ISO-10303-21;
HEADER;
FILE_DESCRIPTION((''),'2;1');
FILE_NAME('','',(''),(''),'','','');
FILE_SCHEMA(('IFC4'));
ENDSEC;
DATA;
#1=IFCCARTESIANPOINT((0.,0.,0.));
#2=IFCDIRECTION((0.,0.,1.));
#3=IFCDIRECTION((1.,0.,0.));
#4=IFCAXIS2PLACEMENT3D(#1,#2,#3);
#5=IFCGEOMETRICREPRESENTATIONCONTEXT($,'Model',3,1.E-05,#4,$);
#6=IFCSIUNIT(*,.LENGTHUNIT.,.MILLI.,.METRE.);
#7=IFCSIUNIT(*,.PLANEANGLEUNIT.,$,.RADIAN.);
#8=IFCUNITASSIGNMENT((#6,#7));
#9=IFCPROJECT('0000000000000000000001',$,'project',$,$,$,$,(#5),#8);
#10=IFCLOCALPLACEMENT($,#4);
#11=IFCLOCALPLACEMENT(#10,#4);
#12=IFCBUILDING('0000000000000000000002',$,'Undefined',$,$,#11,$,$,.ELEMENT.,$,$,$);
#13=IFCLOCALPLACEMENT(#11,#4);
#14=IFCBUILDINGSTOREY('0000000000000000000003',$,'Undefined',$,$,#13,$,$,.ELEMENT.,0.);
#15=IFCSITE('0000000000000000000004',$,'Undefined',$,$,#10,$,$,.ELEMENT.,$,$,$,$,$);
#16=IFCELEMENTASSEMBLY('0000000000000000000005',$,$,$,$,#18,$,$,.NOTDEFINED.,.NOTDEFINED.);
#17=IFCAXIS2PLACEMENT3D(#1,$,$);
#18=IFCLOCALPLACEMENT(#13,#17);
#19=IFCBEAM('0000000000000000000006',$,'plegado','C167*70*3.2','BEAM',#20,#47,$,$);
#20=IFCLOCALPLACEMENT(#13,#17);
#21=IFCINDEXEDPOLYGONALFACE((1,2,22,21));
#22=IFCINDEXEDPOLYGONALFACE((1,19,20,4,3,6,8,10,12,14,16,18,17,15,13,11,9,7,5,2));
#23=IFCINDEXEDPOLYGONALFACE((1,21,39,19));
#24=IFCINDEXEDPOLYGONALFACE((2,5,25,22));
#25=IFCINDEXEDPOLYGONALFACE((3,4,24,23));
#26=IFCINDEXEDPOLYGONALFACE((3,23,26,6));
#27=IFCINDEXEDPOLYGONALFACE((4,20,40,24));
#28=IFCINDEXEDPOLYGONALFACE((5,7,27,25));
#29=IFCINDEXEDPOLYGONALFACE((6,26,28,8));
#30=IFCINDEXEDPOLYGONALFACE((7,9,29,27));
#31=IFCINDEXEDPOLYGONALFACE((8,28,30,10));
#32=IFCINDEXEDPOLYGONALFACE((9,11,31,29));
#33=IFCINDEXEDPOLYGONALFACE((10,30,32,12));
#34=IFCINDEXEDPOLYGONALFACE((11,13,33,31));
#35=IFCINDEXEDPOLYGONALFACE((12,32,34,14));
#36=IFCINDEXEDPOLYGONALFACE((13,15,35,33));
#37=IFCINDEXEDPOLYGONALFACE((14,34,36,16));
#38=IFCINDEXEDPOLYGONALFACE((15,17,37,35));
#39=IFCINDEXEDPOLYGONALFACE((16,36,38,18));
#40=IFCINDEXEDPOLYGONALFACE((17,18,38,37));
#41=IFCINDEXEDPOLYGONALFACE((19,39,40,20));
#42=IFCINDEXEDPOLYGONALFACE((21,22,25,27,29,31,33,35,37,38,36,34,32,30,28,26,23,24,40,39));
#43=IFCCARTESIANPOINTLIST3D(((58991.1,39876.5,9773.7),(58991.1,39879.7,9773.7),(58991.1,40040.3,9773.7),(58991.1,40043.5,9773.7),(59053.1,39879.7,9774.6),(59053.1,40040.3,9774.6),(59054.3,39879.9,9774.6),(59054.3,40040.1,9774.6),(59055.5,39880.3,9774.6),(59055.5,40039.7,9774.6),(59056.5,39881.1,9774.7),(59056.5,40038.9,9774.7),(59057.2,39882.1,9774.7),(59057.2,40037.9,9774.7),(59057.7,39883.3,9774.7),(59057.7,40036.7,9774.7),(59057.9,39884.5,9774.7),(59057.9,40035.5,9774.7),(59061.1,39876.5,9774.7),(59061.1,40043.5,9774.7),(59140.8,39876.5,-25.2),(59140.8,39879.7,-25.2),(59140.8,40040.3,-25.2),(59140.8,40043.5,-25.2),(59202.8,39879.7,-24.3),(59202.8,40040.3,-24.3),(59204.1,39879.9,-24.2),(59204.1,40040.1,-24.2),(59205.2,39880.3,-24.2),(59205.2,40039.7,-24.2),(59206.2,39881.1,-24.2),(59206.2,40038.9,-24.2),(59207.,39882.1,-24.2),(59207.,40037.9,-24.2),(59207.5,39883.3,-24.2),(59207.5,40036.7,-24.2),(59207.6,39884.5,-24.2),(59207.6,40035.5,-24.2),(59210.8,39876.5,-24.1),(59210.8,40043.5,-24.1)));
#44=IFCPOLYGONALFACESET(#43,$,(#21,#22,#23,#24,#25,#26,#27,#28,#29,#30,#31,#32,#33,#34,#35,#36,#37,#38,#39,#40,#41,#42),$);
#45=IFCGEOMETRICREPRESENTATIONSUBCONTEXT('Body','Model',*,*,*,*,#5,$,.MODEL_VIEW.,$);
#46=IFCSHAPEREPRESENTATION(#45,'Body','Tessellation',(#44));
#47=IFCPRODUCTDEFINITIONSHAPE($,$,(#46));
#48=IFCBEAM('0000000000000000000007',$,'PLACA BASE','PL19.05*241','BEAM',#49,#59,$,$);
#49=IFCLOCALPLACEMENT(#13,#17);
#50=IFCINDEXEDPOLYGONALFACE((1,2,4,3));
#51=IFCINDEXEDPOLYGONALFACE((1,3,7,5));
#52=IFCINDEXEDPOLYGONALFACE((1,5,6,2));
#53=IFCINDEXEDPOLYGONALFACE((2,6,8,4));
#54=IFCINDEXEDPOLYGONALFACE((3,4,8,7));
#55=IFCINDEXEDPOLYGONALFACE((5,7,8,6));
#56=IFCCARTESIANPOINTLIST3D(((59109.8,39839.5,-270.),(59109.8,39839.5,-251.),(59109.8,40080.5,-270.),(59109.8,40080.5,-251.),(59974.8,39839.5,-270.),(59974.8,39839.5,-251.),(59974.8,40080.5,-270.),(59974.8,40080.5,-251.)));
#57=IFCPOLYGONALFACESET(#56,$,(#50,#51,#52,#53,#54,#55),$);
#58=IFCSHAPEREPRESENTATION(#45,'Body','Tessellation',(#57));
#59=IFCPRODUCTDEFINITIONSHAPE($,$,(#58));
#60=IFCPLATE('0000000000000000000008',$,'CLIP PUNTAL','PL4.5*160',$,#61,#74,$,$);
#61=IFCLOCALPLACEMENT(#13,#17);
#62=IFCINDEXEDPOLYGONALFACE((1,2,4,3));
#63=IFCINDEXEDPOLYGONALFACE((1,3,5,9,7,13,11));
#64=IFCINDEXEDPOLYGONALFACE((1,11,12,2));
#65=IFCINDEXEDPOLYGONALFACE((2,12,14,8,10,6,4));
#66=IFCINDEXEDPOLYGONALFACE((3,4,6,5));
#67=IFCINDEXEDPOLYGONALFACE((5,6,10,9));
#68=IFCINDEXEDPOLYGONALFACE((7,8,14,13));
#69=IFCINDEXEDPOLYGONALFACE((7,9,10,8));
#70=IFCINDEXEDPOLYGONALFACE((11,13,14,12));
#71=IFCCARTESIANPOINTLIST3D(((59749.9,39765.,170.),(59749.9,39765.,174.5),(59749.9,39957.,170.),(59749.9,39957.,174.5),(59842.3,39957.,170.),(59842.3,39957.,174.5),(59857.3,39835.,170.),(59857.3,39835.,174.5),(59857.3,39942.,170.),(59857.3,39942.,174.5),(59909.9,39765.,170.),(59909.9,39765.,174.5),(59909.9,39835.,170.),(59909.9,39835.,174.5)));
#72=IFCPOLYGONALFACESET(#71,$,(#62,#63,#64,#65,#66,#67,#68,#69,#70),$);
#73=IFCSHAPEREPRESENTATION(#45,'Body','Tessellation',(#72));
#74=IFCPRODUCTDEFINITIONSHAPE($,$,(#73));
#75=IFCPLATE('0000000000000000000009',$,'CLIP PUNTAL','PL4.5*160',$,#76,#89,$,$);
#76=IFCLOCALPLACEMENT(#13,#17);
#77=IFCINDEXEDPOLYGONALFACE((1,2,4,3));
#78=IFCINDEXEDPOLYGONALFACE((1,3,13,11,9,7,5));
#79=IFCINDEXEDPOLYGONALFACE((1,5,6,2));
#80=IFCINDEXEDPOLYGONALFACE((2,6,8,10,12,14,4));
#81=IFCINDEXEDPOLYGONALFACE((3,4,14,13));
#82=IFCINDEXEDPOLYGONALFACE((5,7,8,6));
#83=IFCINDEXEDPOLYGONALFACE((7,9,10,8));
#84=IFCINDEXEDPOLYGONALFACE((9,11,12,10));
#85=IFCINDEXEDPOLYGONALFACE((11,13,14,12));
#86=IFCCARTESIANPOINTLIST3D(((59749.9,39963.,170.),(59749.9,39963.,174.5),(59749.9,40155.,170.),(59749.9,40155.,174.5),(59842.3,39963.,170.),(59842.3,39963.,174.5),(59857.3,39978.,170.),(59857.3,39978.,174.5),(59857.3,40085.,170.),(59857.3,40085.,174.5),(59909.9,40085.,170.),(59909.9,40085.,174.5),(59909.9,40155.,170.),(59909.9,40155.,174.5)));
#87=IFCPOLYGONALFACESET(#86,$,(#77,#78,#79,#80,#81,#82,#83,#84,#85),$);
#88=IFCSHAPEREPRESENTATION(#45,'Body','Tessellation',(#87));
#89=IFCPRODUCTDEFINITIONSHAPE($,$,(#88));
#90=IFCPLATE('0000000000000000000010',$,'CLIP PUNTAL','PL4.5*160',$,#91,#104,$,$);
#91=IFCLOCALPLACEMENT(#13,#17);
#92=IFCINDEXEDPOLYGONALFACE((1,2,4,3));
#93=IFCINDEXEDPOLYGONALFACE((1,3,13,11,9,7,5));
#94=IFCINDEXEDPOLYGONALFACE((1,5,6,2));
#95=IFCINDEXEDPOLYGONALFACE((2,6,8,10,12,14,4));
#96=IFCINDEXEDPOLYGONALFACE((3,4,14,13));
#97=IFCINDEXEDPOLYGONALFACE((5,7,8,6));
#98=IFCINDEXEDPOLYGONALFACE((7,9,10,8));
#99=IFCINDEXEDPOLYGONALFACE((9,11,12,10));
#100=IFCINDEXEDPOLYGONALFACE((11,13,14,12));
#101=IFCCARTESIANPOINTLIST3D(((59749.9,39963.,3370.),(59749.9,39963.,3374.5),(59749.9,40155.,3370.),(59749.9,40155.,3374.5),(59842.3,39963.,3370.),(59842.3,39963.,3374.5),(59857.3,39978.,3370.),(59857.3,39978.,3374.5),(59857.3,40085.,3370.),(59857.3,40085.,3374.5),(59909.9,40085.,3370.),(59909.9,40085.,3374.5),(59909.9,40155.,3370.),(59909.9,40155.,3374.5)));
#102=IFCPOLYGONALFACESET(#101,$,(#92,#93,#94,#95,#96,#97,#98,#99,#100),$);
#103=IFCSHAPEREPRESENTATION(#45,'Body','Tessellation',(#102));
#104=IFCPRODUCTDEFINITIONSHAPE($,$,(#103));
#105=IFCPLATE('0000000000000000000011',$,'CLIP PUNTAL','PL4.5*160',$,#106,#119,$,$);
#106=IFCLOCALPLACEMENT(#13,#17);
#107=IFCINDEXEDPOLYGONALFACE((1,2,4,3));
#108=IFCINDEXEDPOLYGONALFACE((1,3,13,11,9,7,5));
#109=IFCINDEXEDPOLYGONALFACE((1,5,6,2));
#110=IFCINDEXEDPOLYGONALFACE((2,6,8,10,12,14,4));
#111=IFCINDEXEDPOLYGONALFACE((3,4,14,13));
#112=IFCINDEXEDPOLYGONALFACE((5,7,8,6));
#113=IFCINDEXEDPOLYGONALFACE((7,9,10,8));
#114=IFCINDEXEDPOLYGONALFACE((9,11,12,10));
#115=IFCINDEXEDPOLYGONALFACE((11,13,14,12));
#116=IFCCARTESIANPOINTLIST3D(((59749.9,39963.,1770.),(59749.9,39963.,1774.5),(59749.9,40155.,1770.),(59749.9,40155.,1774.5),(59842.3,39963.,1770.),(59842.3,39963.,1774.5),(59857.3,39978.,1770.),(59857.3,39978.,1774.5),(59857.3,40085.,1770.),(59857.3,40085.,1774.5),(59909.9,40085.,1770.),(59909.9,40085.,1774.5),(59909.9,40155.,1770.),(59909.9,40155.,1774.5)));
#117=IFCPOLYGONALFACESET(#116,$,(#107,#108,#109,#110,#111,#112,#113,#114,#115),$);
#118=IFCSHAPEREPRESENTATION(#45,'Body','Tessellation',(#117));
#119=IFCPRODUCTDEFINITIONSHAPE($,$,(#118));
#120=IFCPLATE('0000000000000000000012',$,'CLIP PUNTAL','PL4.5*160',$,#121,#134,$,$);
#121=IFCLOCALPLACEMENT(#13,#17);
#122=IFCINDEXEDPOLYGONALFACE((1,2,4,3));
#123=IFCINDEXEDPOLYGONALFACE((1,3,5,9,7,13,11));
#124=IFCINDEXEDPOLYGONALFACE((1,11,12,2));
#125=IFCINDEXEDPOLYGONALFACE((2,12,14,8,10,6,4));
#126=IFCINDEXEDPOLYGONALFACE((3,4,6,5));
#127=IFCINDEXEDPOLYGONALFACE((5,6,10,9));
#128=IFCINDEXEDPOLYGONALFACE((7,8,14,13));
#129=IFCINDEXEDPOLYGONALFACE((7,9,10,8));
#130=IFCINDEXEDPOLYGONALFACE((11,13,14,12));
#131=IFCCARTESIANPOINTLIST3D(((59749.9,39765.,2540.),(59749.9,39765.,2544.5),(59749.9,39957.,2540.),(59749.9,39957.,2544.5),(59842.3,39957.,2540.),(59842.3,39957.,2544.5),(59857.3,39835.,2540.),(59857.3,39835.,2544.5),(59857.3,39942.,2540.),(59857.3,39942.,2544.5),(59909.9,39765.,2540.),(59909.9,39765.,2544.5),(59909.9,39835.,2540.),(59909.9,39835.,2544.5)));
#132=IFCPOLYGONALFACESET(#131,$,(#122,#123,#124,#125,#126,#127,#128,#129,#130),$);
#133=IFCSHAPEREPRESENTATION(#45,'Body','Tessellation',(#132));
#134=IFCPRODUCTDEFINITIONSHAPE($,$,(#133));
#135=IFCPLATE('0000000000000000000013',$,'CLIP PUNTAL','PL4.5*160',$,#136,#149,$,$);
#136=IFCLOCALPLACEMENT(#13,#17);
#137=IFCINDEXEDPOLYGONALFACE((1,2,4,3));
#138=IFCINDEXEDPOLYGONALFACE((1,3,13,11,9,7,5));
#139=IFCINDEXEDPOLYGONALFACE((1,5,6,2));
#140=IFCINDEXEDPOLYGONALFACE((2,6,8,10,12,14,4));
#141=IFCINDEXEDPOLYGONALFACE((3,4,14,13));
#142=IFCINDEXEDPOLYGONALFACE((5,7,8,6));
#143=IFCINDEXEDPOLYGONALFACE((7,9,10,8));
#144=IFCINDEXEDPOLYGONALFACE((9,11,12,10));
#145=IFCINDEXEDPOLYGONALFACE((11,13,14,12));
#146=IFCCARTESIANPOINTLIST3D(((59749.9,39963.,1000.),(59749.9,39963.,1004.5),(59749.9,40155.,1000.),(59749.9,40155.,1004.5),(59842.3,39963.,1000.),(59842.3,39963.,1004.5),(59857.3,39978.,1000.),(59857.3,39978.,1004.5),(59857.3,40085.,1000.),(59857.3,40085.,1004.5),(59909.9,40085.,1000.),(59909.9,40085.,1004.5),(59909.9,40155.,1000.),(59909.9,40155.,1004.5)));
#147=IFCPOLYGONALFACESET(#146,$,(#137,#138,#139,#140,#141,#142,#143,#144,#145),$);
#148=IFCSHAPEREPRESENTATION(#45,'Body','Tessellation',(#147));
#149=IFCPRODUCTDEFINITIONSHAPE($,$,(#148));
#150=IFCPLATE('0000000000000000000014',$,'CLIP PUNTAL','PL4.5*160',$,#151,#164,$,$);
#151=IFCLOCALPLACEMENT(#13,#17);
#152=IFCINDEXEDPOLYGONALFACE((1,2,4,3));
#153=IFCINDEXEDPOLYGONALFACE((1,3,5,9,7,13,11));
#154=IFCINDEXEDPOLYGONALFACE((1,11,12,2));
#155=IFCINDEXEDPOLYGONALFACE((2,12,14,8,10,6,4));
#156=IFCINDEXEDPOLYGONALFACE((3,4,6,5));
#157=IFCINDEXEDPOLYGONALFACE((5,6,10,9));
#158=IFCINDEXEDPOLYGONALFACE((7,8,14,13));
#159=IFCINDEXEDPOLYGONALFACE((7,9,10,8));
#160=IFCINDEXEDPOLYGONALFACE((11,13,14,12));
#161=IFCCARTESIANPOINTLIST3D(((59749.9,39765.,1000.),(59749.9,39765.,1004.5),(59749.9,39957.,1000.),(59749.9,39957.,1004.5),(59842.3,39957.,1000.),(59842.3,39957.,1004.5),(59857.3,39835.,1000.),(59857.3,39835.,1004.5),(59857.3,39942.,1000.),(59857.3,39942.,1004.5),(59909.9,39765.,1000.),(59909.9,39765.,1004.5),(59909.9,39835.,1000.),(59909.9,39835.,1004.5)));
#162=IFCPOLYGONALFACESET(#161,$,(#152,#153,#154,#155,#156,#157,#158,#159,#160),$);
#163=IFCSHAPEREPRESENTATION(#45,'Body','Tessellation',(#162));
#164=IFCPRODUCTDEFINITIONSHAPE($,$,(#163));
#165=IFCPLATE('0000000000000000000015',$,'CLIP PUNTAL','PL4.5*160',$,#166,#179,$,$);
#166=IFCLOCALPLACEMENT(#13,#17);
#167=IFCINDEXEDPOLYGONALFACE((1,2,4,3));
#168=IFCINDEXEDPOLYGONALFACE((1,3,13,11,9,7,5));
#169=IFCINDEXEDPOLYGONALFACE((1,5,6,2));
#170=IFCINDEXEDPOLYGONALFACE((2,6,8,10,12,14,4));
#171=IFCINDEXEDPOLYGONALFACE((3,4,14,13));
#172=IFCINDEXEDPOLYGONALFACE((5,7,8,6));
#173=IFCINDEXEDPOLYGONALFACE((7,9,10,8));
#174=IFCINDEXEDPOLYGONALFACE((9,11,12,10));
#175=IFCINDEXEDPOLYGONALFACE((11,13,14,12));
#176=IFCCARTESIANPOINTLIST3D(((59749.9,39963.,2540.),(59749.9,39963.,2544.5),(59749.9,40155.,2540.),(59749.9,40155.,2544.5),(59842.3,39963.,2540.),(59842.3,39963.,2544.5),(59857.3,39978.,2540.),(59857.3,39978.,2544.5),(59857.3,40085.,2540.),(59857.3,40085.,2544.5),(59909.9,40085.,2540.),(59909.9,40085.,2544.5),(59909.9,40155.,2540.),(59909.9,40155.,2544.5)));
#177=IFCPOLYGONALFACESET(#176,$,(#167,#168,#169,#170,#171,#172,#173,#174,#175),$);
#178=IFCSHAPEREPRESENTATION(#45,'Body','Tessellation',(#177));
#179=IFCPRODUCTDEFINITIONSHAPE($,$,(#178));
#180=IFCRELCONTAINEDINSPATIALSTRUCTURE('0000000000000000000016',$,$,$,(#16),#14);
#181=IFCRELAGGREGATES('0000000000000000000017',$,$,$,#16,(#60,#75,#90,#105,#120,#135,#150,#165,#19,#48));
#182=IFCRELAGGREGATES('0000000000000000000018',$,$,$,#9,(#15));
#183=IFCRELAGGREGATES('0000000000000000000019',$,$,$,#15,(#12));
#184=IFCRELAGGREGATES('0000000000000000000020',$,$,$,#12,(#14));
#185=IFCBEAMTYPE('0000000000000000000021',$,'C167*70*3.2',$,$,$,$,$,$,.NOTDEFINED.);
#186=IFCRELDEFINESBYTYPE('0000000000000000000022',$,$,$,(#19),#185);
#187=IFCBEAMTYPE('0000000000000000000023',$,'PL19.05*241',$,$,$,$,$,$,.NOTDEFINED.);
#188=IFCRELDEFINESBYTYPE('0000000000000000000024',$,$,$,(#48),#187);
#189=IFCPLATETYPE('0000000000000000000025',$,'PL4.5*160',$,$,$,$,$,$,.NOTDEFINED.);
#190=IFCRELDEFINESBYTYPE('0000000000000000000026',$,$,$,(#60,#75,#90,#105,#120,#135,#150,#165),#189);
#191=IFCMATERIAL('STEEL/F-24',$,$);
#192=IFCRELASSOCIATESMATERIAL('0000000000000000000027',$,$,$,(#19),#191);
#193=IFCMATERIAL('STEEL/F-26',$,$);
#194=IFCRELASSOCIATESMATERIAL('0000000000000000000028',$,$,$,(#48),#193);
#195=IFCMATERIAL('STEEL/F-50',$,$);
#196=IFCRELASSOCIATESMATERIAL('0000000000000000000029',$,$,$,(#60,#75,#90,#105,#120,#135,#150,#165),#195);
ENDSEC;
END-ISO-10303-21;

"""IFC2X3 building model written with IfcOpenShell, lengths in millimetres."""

from ifc_helpers import new_model, si_unit, frame, origin_with_axes, origin_2d_with_axis, place, context, subcontext, project, spatial, polyline, rectangle, u_section, outline, extrude, material, type_object, element, aggregate, save


model = new_model("IFC2X3")

# Units and contexts
model_context = context("Model", 3, precision=1e-05, world=origin_with_axes())
body_context = subcontext(model_context, "Body", "Model", "MODEL_VIEW")
ifc_project = project(units=[si_unit("LENGTHUNIT", "METRE", prefix="MILLI"), si_unit("PLANEANGLEUNIT", "RADIAN")], contexts=[model_context])

# Site, building, storey
site_placement = place(None, origin_with_axes())
site = spatial("IfcSite", under=ifc_project, at=site_placement, Name="Undefined", CompositionType="ELEMENT")
building_placement = place(site_placement, origin_with_axes())
building = spatial("IfcBuilding", under=site, at=building_placement, Name="Undefined", CompositionType="ELEMENT")
storey_placement = place(building_placement, origin_with_axes())
storey = spatial("IfcBuildingStorey", under=building, at=storey_placement, Name="Undefined", CompositionType="ELEMENT", Elevation=0.0)

# Element assembly, beams, plates
assembly_1_placement = place(storey_placement, origin_with_axes())
assembly_1 = element("IfcElementAssembly", 1, at=assembly_1_placement, inside=storey, AssemblyPlace="NOTDEFINED", PredefinedType="NOTDEFINED")
ifc_material_1 = material(Name="STEEL/F-24")
beam_type_1 = type_object("IfcBeamType", Name="C167*70*3.2", PredefinedType="NOTDEFINED")
beam_1_placement = place(assembly_1_placement, frame((59175.8, 39960.0, -24.7), z_axis=(0.0, 1.0, 0.0), x_axis=(-0.015279, 0.0, 0.999883)))
beam_1 = element("IfcBeam", 2, at=beam_1_placement, type_object=beam_type_1, material=ifc_material_1, Name="plegado", Description="C167*70*3.2", ObjectType="BEAM", context=body_context, shape_type="SweptSolid", body=[
    extrude(u_section(Depth=167.0, FlangeWidth=70.0, WebThickness=3.2, FlangeThickness=3.2, FilletRadius=4.8, at=origin_2d_with_axis()), frame((9800.0, 0.0, 0.0), z_axis=(-1.0, 0.0, 0.0), x_axis=(0.0, -1.0, 0.0)), (0.0, 0.0, 1.0), 9800.0),
])
ifc_material_2 = material(Name="STEEL/F-26")
beam_type_2 = type_object("IfcBeamType", Name="PL19.05*241", PredefinedType="NOTDEFINED")
beam_2_placement = place(assembly_1_placement, frame((59974.8, 39960.0, -260.5), z_axis=(0.0, -1.0, 0.0), x_axis=(-1.0, 0.0, 0.0)))
beam_2 = element("IfcBeam", 3, at=beam_2_placement, type_object=beam_type_2, material=ifc_material_2, Name="PLACA BASE", Description="PL19.05*241", ObjectType="BEAM", context=body_context, shape_type="SweptSolid", body=[
    extrude(rectangle(XDim=19.1, YDim=241.0, at=origin_2d_with_axis()), frame((865.0, 0.0, 0.0), z_axis=(-1.0, 0.0, 0.0), x_axis=(0.0, -1.0, 0.0)), (0.0, 0.0, 1.0), 865.0),
])
ifc_material_3 = material(Name="STEEL/F-50")
plate_type_1 = type_object("IfcPlateType", Name="PL4.5*160", PredefinedType="NOTDEFINED")
plate_1_placement = place(assembly_1_placement, frame((59857.3, 39957.0, 172.3), z_axis=(0.0, 0.0, -1.0), x_axis=(0.0, -1.0, 0.0)))
plate_1 = element("IfcPlate", 4, at=plate_1_placement, type_object=plate_type_1, material=ifc_material_3, Name="CLIP PUNTAL", Description="PL4.5*160", context=body_context, shape_type="SweptSolid", body=[
    extrude(outline(polyline([(0.0, 15.0), (15.0, 0.0), (122.0, 0.0), (122.0, -52.6), (192.0, -52.6), (192.0, 107.4), (0.0, 107.4), (0.0, 15.0)])), frame((0.0, 0.0, -2.2), z_axis=(0.0, 0.0, 1.0), x_axis=(1.0, 0.0, 0.0)), (0.0, 0.0, 1.0), 4.5),
])
plate_2_placement = place(assembly_1_placement, frame((59857.3, 39963.0, 172.3), z_axis=(0.0, 0.0, 1.0), x_axis=(0.0, 1.0, 0.0)))
plate_2 = element("IfcPlate", 5, at=plate_2_placement, type_object=plate_type_1, material=ifc_material_3, Name="CLIP PUNTAL", Description="PL4.5*160", context=body_context, shape_type="SweptSolid", body=[
    extrude(outline(polyline([(0.0, 15.0), (15.0, 0.0), (122.0, 0.0), (122.0, -52.6), (192.0, -52.6), (192.0, 107.4), (0.0, 107.4), (0.0, 15.0)])), frame((0.0, 0.0, -2.2), z_axis=(0.0, 0.0, 1.0), x_axis=(1.0, 0.0, 0.0)), (0.0, 0.0, 1.0), 4.5),
])
plate_3_placement = place(assembly_1_placement, frame((59857.3, 39963.0, 3372.3), z_axis=(0.0, 0.0, 1.0), x_axis=(0.0, 1.0, 0.0)))
plate_3 = element("IfcPlate", 6, at=plate_3_placement, type_object=plate_type_1, material=ifc_material_3, Name="CLIP PUNTAL", Description="PL4.5*160", context=body_context, shape_type="SweptSolid", body=[
    extrude(outline(polyline([(0.0, 15.0), (15.0, 0.0), (122.0, 0.0), (122.0, -52.6), (192.0, -52.6), (192.0, 107.4), (0.0, 107.4), (0.0, 15.0)])), frame((0.0, 0.0, -2.2), z_axis=(0.0, 0.0, 1.0), x_axis=(1.0, 0.0, 0.0)), (0.0, 0.0, 1.0), 4.5),
])
plate_4_placement = place(assembly_1_placement, frame((59857.3, 39963.0, 1772.2), z_axis=(0.0, 0.0, 1.0), x_axis=(0.0, 1.0, 0.0)))
plate_4 = element("IfcPlate", 7, at=plate_4_placement, type_object=plate_type_1, material=ifc_material_3, Name="CLIP PUNTAL", Description="PL4.5*160", context=body_context, shape_type="SweptSolid", body=[
    extrude(outline(polyline([(0.0, 15.0), (15.0, 0.0), (122.0, 0.0), (122.0, -52.6), (192.0, -52.6), (192.0, 107.4), (0.0, 107.4), (0.0, 15.0)])), frame((0.0, 0.0, -2.2), z_axis=(0.0, 0.0, 1.0), x_axis=(1.0, 0.0, 0.0)), (0.0, 0.0, 1.0), 4.5),
])
plate_5_placement = place(assembly_1_placement, frame((59857.3, 39957.0, 2542.2), z_axis=(0.0, 0.0, -1.0), x_axis=(0.0, -1.0, 0.0)))
plate_5 = element("IfcPlate", 8, at=plate_5_placement, type_object=plate_type_1, material=ifc_material_3, Name="CLIP PUNTAL", Description="PL4.5*160", context=body_context, shape_type="SweptSolid", body=[
    extrude(outline(polyline([(0.0, 15.0), (15.0, 0.0), (122.0, 0.0), (122.0, -52.6), (192.0, -52.6), (192.0, 107.4), (0.0, 107.4), (0.0, 15.0)])), frame((0.0, 0.0, -2.2), z_axis=(0.0, 0.0, 1.0), x_axis=(1.0, 0.0, 0.0)), (0.0, 0.0, 1.0), 4.5),
])
plate_6_placement = place(assembly_1_placement, frame((59857.3, 39963.0, 1002.2), z_axis=(0.0, 0.0, 1.0), x_axis=(0.0, 1.0, 0.0)))
plate_6 = element("IfcPlate", 9, at=plate_6_placement, type_object=plate_type_1, material=ifc_material_3, Name="CLIP PUNTAL", Description="PL4.5*160", context=body_context, shape_type="SweptSolid", body=[
    extrude(outline(polyline([(0.0, 15.0), (15.0, 0.0), (122.0, 0.0), (122.0, -52.6), (192.0, -52.6), (192.0, 107.4), (0.0, 107.4), (0.0, 15.0)])), frame((0.0, 0.0, -2.2), z_axis=(0.0, 0.0, 1.0), x_axis=(1.0, 0.0, 0.0)), (0.0, 0.0, 1.0), 4.5),
])
plate_7_placement = place(assembly_1_placement, frame((59857.3, 39957.0, 1002.2), z_axis=(0.0, 0.0, -1.0), x_axis=(0.0, -1.0, 0.0)))
plate_7 = element("IfcPlate", 10, at=plate_7_placement, type_object=plate_type_1, material=ifc_material_3, Name="CLIP PUNTAL", Description="PL4.5*160", context=body_context, shape_type="SweptSolid", body=[
    extrude(outline(polyline([(0.0, 15.0), (15.0, 0.0), (122.0, 0.0), (122.0, -52.6), (192.0, -52.6), (192.0, 107.4), (0.0, 107.4), (0.0, 15.0)])), frame((0.0, 0.0, -2.2), z_axis=(0.0, 0.0, 1.0), x_axis=(1.0, 0.0, 0.0)), (0.0, 0.0, 1.0), 4.5),
])
plate_8_placement = place(assembly_1_placement, frame((59857.3, 39963.0, 2542.2), z_axis=(0.0, 0.0, 1.0), x_axis=(0.0, 1.0, 0.0)))
plate_8 = element("IfcPlate", 11, at=plate_8_placement, type_object=plate_type_1, material=ifc_material_3, Name="CLIP PUNTAL", Description="PL4.5*160", context=body_context, shape_type="SweptSolid", body=[
    extrude(outline(polyline([(0.0, 15.0), (15.0, 0.0), (122.0, 0.0), (122.0, -52.6), (192.0, -52.6), (192.0, 107.4), (0.0, 107.4), (0.0, 15.0)])), frame((0.0, 0.0, -2.2), z_axis=(0.0, 0.0, 1.0), x_axis=(1.0, 0.0, 0.0)), (0.0, 0.0, 1.0), 4.5),
])

aggregate(assembly_1, [plate_1, plate_2, plate_3, plate_4, plate_5, plate_6, plate_7, plate_8, beam_1, beam_2])

save(model, "model.ifc")
